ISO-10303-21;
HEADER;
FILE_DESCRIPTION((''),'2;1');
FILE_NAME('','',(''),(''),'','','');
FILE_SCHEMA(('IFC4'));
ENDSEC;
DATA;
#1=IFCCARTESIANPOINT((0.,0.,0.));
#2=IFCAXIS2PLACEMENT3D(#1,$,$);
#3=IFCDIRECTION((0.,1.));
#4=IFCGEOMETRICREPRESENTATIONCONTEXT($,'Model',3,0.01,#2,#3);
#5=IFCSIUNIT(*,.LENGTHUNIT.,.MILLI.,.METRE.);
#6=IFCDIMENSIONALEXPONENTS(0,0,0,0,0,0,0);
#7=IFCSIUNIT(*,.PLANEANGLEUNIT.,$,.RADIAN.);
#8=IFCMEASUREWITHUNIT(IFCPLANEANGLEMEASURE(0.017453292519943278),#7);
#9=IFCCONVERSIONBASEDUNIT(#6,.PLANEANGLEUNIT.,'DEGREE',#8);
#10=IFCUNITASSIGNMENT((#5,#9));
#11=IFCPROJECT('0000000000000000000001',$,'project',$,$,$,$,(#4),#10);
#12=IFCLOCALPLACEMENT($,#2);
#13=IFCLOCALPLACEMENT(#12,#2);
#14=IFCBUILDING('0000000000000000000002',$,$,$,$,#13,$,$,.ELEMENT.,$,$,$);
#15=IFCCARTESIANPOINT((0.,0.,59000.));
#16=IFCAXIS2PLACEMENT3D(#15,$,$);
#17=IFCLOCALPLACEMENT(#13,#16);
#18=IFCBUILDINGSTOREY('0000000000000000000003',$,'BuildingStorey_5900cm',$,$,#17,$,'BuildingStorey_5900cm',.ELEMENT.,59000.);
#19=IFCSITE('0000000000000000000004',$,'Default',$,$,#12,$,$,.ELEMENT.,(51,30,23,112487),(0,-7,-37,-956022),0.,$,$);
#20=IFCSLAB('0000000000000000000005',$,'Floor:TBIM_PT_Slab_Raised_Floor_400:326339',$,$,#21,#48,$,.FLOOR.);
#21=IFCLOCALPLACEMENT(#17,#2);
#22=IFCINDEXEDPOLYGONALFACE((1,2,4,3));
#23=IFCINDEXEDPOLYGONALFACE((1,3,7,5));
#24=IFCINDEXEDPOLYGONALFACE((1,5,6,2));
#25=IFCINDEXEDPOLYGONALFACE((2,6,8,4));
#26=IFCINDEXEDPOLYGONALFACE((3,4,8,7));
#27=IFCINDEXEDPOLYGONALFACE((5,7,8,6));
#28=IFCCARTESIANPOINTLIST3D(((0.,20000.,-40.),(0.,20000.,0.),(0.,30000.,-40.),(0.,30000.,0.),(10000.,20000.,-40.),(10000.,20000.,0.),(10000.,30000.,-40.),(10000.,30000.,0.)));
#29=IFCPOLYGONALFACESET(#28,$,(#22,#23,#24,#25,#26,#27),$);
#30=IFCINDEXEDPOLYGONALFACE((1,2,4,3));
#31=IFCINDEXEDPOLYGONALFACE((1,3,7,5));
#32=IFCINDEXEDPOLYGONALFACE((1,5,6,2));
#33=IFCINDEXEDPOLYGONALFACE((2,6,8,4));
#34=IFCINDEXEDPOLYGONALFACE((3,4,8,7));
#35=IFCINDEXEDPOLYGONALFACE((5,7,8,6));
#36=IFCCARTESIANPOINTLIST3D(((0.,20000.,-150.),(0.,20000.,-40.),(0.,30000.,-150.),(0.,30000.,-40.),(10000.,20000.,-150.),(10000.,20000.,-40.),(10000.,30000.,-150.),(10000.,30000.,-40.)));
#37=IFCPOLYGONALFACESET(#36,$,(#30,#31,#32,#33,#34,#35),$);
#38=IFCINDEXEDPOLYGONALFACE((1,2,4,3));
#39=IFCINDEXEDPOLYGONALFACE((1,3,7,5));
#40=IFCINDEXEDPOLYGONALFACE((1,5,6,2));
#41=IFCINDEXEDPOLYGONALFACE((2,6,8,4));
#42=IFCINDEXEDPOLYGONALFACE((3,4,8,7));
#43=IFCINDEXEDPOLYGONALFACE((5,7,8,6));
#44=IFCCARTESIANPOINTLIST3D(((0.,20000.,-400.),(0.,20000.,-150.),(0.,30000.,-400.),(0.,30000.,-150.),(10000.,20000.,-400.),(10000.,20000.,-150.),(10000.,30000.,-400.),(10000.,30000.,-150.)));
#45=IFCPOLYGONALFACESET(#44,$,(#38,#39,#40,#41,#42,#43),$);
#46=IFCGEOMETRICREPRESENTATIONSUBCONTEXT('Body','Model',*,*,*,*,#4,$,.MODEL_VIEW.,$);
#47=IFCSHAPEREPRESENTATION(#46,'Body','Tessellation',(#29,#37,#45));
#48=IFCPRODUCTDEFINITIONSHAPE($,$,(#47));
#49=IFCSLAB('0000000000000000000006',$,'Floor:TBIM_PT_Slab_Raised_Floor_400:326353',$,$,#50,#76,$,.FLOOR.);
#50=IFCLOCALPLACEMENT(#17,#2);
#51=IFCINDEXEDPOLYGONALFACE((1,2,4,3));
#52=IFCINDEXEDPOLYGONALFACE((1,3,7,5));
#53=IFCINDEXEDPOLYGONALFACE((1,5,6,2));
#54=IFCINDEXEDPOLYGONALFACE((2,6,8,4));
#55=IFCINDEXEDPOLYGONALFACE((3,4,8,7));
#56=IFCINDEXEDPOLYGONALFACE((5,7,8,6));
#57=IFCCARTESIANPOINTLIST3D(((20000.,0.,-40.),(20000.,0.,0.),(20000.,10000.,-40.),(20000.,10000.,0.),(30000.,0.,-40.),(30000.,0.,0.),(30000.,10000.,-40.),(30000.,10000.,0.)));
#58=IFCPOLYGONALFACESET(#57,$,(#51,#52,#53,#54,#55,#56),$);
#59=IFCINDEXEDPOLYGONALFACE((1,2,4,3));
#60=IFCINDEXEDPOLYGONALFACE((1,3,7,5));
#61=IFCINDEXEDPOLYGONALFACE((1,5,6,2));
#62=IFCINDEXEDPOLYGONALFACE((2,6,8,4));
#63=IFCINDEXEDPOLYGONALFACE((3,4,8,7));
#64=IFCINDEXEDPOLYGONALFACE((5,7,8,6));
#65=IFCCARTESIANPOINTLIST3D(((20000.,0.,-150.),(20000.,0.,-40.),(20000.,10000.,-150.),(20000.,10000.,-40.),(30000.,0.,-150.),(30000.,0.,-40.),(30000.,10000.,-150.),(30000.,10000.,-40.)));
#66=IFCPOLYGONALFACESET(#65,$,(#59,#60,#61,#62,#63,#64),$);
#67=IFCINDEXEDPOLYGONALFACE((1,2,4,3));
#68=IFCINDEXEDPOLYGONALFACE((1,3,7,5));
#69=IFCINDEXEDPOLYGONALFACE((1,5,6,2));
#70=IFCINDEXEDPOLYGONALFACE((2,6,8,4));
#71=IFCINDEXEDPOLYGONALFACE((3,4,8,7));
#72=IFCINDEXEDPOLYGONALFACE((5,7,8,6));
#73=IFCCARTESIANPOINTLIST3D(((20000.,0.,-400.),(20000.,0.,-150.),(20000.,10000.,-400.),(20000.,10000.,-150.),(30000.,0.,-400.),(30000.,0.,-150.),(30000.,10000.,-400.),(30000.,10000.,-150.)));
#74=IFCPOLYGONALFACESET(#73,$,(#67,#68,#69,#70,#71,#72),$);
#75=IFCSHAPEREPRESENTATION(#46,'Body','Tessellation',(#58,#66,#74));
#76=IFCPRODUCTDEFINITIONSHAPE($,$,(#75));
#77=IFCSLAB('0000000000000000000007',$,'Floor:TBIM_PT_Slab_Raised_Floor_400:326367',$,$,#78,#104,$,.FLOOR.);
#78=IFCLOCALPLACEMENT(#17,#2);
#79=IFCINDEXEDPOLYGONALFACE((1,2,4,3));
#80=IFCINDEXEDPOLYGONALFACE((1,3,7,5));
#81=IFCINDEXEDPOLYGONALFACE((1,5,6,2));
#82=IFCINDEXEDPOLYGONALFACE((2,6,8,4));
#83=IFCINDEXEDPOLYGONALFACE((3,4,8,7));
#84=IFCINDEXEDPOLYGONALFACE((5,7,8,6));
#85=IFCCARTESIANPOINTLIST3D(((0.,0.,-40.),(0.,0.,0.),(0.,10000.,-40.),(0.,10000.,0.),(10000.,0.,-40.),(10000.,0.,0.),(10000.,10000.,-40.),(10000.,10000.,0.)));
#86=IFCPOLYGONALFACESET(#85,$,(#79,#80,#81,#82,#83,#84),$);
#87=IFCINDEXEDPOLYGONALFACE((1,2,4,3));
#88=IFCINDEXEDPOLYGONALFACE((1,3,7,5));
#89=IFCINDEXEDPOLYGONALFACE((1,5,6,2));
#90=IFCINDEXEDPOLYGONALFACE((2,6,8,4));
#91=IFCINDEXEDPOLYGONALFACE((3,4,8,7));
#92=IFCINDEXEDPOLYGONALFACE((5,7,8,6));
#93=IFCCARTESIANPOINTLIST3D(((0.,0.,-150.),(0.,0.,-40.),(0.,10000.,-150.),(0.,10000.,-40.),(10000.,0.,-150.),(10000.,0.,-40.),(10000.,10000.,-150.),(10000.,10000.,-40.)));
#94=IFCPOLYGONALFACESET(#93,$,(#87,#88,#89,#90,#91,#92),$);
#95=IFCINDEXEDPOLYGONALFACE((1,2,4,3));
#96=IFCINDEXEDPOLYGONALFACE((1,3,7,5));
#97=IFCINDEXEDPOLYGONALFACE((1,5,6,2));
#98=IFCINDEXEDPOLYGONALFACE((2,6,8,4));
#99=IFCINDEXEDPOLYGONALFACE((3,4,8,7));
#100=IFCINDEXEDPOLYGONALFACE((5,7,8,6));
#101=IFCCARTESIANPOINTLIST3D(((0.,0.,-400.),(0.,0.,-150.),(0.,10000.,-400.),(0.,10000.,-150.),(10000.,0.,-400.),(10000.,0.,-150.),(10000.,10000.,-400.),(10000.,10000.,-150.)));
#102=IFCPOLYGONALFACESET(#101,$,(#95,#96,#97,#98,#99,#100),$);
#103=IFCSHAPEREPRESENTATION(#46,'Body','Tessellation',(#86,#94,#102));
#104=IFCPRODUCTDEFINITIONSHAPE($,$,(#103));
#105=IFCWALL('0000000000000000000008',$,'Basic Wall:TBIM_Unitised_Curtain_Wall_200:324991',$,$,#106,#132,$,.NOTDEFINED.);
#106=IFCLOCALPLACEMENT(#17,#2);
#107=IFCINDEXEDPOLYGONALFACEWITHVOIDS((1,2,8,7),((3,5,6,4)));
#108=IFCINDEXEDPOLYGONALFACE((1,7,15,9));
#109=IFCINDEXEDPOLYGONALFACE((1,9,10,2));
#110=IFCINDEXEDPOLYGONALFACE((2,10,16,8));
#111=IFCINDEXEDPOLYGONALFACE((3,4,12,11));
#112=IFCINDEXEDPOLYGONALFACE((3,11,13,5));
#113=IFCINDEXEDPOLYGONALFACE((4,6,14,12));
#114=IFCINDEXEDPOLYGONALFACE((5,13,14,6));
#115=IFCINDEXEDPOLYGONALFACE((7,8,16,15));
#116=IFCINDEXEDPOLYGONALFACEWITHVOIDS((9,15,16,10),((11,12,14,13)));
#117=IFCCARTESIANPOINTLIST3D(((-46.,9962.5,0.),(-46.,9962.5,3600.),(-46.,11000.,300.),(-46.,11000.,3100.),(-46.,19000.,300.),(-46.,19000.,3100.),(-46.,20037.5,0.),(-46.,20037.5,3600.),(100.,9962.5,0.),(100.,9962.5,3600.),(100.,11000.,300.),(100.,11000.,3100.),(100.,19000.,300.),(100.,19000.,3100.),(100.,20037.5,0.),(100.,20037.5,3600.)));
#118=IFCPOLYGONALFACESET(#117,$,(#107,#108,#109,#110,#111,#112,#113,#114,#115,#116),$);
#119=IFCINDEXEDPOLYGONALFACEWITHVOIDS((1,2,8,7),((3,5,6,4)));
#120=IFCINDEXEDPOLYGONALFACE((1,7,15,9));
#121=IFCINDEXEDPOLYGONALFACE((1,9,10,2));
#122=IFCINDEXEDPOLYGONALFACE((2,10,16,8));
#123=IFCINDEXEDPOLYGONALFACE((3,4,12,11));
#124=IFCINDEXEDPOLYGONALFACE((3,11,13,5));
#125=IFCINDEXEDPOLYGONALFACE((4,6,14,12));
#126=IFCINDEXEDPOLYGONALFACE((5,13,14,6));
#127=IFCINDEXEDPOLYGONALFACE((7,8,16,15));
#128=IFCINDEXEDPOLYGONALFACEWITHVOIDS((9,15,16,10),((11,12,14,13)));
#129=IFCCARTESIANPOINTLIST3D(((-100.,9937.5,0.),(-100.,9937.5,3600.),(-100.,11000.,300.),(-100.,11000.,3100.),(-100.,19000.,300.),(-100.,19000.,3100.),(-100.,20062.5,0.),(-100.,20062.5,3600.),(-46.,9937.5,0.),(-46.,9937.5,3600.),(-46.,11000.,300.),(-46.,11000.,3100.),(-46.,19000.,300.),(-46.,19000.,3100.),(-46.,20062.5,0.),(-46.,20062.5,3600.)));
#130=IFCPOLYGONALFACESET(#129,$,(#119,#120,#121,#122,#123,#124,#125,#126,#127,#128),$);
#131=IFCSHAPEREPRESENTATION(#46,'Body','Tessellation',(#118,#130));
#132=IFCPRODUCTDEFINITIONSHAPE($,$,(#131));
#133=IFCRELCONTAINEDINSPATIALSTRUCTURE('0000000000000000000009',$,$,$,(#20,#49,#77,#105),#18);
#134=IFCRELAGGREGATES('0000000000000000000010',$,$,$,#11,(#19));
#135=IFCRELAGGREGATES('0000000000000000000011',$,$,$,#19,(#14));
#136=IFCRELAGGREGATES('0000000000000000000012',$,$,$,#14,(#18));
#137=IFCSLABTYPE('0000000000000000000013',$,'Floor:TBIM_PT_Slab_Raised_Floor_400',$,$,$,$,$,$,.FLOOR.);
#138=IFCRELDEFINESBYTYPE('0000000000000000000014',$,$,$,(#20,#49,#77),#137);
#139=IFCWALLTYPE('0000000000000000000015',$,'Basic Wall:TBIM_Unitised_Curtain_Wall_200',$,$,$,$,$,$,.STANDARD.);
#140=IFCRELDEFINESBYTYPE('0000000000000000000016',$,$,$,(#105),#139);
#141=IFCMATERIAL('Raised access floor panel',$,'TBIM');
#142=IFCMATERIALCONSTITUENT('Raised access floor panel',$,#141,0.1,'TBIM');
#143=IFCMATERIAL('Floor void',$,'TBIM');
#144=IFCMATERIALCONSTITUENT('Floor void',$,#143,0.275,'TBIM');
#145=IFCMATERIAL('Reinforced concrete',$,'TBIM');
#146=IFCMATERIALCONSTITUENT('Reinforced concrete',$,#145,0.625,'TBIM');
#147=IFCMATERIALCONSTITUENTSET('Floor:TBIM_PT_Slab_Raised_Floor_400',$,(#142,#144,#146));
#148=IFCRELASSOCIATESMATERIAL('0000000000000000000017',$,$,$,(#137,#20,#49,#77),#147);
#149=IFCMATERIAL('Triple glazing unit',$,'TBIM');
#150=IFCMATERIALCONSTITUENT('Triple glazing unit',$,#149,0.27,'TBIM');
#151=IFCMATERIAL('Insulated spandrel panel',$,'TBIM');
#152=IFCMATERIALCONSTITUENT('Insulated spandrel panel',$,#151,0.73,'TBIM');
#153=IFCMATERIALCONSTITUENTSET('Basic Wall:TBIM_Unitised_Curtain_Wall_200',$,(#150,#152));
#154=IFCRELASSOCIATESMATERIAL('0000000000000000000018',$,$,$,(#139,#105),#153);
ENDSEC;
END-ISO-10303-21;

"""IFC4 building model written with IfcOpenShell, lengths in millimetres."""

from ifc_helpers import new_model, entity, si_unit, converted_unit, direction, frame, origin, place, context, subcontext, project, spatial, indexed_curve, outline, extrude, material, constituent, constituent_set, type_object, element, save


model = new_model("IFC4")

# Units and contexts
model_context = context("Model", 3, precision=0.01, world=origin(), true_north=direction((0.0, 1.0)))
body_context = subcontext(model_context, "Body", "Model", "MODEL_VIEW")
ifc_project = project(units=[si_unit("LENGTHUNIT", "METRE", prefix="MILLI"), converted_unit("PLANEANGLEUNIT", "DEGREE", entity("IfcPlaneAngleMeasure", 0.017453292519943278), si_unit("PLANEANGLEUNIT", "RADIAN"), dimensions=[0, 0, 0, 0, 0, 0, 0])], contexts=[model_context])

# Site, building, storey
site_placement = place(None, origin())
site = spatial("IfcSite", under=ifc_project, at=site_placement, Name="Default", CompositionType="ELEMENT", RefLatitude=(51, 30, 23, 112487), RefLongitude=(0, -7, -37, -956022), RefElevation=0.0)
building_placement = place(site_placement, origin())
building = spatial("IfcBuilding", under=site, at=building_placement, CompositionType="ELEMENT")
storey_placement = place(building_placement, frame((0.0, 0.0, 59000.0)))
storey = spatial("IfcBuildingStorey", under=building, at=storey_placement, Name="BuildingStorey_5900cm", LongName="BuildingStorey_5900cm", CompositionType="ELEMENT", Elevation=59000.0)

# Slabs
ifc_material_1 = material(Name="Raised access floor panel", Category="TBIM")
ifc_constituent_1 = constituent(ifc_material_1, Name="Raised access floor panel", Category="TBIM", fraction=0.1)
ifc_material_2 = material(Name="Floor void", Category="TBIM")
ifc_constituent_2 = constituent(ifc_material_2, Name="Floor void", Category="TBIM", fraction=0.275)
ifc_material_3 = material(Name="Reinforced concrete", Category="TBIM")
ifc_constituent_3 = constituent(ifc_material_3, Name="Reinforced concrete", Category="TBIM", fraction=0.625)
ifc_constituent_set_1 = constituent_set(constituents=[ifc_constituent_1, ifc_constituent_2, ifc_constituent_3], Name="Floor:TBIM_PT_Slab_Raised_Floor_400")
slab_type = type_object("IfcSlabType", Name="Floor:TBIM_PT_Slab_Raised_Floor_400", PredefinedType="FLOOR", material=ifc_constituent_set_1)
slab_1_placement = place(storey_placement, origin())
element("IfcSlab", 1, at=slab_1_placement, inside=storey, type_object=slab_type, material=ifc_constituent_set_1, Name="Floor:TBIM_PT_Slab_Raised_Floor_400:326339", PredefinedType="FLOOR", context=body_context, shape_type="SweptSolid", body=[
    extrude(outline(indexed_curve([(-5000.0, -5000.0), (5000.0, -5000.0), (5000.0, 5000.0), (-5000.0, 5000.0), (-5000.0, -5000.0)], self_intersect=False)), frame((5000.0, 25000.0, -40.0), z_axis=(0.0, 0.0, 1.0), x_axis=(-1.0, 0.0, 0.0)), (0.0, 0.0, 1.0), 40.0),
    extrude(outline(indexed_curve([(-5000.0, -5000.0), (5000.0, -5000.0), (5000.0, 5000.0), (-5000.0, 5000.0), (-5000.0, -5000.0)], self_intersect=False)), frame((5000.0, 25000.0, -150.0), z_axis=(0.0, 0.0, 1.0), x_axis=(-1.0, 0.0, 0.0)), (0.0, 0.0, 1.0), 110.0),
    extrude(outline(indexed_curve([(-5000.0, -5000.0), (5000.0, -5000.0), (5000.0, 5000.0), (-5000.0, 5000.0), (-5000.0, -5000.0)], self_intersect=False)), frame((5000.0, 25000.0, -400.0), z_axis=(0.0, 0.0, 1.0), x_axis=(-1.0, 0.0, 0.0)), (0.0, 0.0, 1.0), 250.0),
])
slab_2_placement = place(storey_placement, origin())
element("IfcSlab", 2, at=slab_2_placement, inside=storey, type_object=slab_type, material=ifc_constituent_set_1, Name="Floor:TBIM_PT_Slab_Raised_Floor_400:326353", PredefinedType="FLOOR", context=body_context, shape_type="SweptSolid", body=[
    extrude(outline(indexed_curve([(-5000.0, -5000.0), (5000.0, -5000.0), (5000.0, 5000.0), (-5000.0, 5000.0), (-5000.0, -5000.0)], self_intersect=False)), frame((25000.0, 5000.0, -40.0), z_axis=(0.0, 0.0, 1.0), x_axis=(-1.0, 0.0, 0.0)), (0.0, 0.0, 1.0), 40.0),
    extrude(outline(indexed_curve([(-5000.0, -5000.0), (5000.0, -5000.0), (5000.0, 5000.0), (-5000.0, 5000.0), (-5000.0, -5000.0)], self_intersect=False)), frame((25000.0, 5000.0, -150.0), z_axis=(0.0, 0.0, 1.0), x_axis=(-1.0, 0.0, 0.0)), (0.0, 0.0, 1.0), 110.0),
    extrude(outline(indexed_curve([(-5000.0, -5000.0), (5000.0, -5000.0), (5000.0, 5000.0), (-5000.0, 5000.0), (-5000.0, -5000.0)], self_intersect=False)), frame((25000.0, 5000.0, -400.0), z_axis=(0.0, 0.0, 1.0), x_axis=(-1.0, 0.0, 0.0)), (0.0, 0.0, 1.0), 250.0),
])
slab_3_placement = place(storey_placement, origin())
element("IfcSlab", 3, at=slab_3_placement, inside=storey, type_object=slab_type, material=ifc_constituent_set_1, Name="Floor:TBIM_PT_Slab_Raised_Floor_400:326367", PredefinedType="FLOOR", context=body_context, shape_type="SweptSolid", body=[
    extrude(outline(indexed_curve([(-5000.0, -5000.0), (5000.0, -5000.0), (5000.0, 5000.0), (-5000.0, 5000.0), (-5000.0, -5000.0)], self_intersect=False)), frame((5000.0, 5000.0, -40.0), z_axis=(0.0, 0.0, 1.0), x_axis=(-1.0, 0.0, 0.0)), (0.0, 0.0, 1.0), 40.0),
    extrude(outline(indexed_curve([(-5000.0, -5000.0), (5000.0, -5000.0), (5000.0, 5000.0), (-5000.0, 5000.0), (-5000.0, -5000.0)], self_intersect=False)), frame((5000.0, 5000.0, -150.0), z_axis=(0.0, 0.0, 1.0), x_axis=(-1.0, 0.0, 0.0)), (0.0, 0.0, 1.0), 110.0),
    extrude(outline(indexed_curve([(-5000.0, -5000.0), (5000.0, -5000.0), (5000.0, 5000.0), (-5000.0, 5000.0), (-5000.0, -5000.0)], self_intersect=False)), frame((5000.0, 5000.0, -400.0), z_axis=(0.0, 0.0, 1.0), x_axis=(-1.0, 0.0, 0.0)), (0.0, 0.0, 1.0), 250.0),
])

# Wall, opening
ifc_material_4 = material(Name="Triple glazing unit", Category="TBIM")
ifc_constituent_4 = constituent(ifc_material_4, Name="Triple glazing unit", Category="TBIM", fraction=0.27)
ifc_material_5 = material(Name="Insulated spandrel panel", Category="TBIM")
ifc_constituent_5 = constituent(ifc_material_5, Name="Insulated spandrel panel", Category="TBIM", fraction=0.73)
ifc_constituent_set_2 = constituent_set(constituents=[ifc_constituent_4, ifc_constituent_5], Name="Basic Wall:TBIM_Unitised_Curtain_Wall_200")
wall_type = type_object("IfcWallType", Name="Basic Wall:TBIM_Unitised_Curtain_Wall_200", PredefinedType="STANDARD", material=ifc_constituent_set_2)
wall_1_placement = place(storey_placement, frame((0.0, 9937.5, 0.0), z_axis=(0.0, 0.0, 1.0), x_axis=(0.0, 1.0, 0.0)))
wall_1 = element("IfcWall", 4, at=wall_1_placement, inside=storey, type_object=wall_type, material=ifc_constituent_set_2, Name="Basic Wall:TBIM_Unitised_Curtain_Wall_200:324991", PredefinedType="NOTDEFINED", context=body_context, shape_type="SweptSolid", body=[
    extrude(outline(indexed_curve([(-1800.0, -5037.5), (1800.0, -5037.5), (1800.0, 5037.5), (-1800.0, 5037.5), (-1800.0, -5037.5)], self_intersect=False), holes=[indexed_curve([(1300.0, 4000.0), (1300.0, -4000.0), (-1500.0, -4000.0), (-1500.0, 4000.0), (1300.0, 4000.0)], self_intersect=False)]), frame((5062.5, 46.0, 1800.0), z_axis=(0.0, -1.0, 0.0), x_axis=(0.0, 0.0, 1.0)), (0.0, 0.0, 1.0), 146.0),
    extrude(outline(indexed_curve([(-5062.5, -1800.0), (5062.5, -1800.0), (5062.5, 1800.0), (-5062.5, 1800.0), (-5062.5, -1800.0)], self_intersect=False), holes=[indexed_curve([(-4000.0, 1300.0), (4000.0, 1300.0), (4000.0, -1500.0), (-4000.0, -1500.0), (-4000.0, 1300.0)], self_intersect=False)]), frame((5062.5, 100.0, 1800.0), z_axis=(0.0, -1.0, 0.0), x_axis=(1.0, 0.0, 0.0)), (0.0, 0.0, 1.0), 54.0),
])
opening_1_placement = place(wall_1_placement, frame((1062.5, -100.0, 300.0)))
element("IfcOpeningElement", 5, at=opening_1_placement, cuts=wall_1, PredefinedType="OPENING", context=body_context, shape_type="SweptSolid", body=[
    extrude(outline(indexed_curve([(2800.0, 0.0), (2800.0, 8000.0), (0.0, 8000.0), (0.0, 0.0), (2800.0, 0.0)], self_intersect=False)), frame((0.0, 0.0, 0.0), z_axis=(0.0, 1.0, 0.0), x_axis=(0.0, 0.0, 1.0)), (0.0, 0.0, 1.0), 200.0),
])

save(model, "model.ifc")
